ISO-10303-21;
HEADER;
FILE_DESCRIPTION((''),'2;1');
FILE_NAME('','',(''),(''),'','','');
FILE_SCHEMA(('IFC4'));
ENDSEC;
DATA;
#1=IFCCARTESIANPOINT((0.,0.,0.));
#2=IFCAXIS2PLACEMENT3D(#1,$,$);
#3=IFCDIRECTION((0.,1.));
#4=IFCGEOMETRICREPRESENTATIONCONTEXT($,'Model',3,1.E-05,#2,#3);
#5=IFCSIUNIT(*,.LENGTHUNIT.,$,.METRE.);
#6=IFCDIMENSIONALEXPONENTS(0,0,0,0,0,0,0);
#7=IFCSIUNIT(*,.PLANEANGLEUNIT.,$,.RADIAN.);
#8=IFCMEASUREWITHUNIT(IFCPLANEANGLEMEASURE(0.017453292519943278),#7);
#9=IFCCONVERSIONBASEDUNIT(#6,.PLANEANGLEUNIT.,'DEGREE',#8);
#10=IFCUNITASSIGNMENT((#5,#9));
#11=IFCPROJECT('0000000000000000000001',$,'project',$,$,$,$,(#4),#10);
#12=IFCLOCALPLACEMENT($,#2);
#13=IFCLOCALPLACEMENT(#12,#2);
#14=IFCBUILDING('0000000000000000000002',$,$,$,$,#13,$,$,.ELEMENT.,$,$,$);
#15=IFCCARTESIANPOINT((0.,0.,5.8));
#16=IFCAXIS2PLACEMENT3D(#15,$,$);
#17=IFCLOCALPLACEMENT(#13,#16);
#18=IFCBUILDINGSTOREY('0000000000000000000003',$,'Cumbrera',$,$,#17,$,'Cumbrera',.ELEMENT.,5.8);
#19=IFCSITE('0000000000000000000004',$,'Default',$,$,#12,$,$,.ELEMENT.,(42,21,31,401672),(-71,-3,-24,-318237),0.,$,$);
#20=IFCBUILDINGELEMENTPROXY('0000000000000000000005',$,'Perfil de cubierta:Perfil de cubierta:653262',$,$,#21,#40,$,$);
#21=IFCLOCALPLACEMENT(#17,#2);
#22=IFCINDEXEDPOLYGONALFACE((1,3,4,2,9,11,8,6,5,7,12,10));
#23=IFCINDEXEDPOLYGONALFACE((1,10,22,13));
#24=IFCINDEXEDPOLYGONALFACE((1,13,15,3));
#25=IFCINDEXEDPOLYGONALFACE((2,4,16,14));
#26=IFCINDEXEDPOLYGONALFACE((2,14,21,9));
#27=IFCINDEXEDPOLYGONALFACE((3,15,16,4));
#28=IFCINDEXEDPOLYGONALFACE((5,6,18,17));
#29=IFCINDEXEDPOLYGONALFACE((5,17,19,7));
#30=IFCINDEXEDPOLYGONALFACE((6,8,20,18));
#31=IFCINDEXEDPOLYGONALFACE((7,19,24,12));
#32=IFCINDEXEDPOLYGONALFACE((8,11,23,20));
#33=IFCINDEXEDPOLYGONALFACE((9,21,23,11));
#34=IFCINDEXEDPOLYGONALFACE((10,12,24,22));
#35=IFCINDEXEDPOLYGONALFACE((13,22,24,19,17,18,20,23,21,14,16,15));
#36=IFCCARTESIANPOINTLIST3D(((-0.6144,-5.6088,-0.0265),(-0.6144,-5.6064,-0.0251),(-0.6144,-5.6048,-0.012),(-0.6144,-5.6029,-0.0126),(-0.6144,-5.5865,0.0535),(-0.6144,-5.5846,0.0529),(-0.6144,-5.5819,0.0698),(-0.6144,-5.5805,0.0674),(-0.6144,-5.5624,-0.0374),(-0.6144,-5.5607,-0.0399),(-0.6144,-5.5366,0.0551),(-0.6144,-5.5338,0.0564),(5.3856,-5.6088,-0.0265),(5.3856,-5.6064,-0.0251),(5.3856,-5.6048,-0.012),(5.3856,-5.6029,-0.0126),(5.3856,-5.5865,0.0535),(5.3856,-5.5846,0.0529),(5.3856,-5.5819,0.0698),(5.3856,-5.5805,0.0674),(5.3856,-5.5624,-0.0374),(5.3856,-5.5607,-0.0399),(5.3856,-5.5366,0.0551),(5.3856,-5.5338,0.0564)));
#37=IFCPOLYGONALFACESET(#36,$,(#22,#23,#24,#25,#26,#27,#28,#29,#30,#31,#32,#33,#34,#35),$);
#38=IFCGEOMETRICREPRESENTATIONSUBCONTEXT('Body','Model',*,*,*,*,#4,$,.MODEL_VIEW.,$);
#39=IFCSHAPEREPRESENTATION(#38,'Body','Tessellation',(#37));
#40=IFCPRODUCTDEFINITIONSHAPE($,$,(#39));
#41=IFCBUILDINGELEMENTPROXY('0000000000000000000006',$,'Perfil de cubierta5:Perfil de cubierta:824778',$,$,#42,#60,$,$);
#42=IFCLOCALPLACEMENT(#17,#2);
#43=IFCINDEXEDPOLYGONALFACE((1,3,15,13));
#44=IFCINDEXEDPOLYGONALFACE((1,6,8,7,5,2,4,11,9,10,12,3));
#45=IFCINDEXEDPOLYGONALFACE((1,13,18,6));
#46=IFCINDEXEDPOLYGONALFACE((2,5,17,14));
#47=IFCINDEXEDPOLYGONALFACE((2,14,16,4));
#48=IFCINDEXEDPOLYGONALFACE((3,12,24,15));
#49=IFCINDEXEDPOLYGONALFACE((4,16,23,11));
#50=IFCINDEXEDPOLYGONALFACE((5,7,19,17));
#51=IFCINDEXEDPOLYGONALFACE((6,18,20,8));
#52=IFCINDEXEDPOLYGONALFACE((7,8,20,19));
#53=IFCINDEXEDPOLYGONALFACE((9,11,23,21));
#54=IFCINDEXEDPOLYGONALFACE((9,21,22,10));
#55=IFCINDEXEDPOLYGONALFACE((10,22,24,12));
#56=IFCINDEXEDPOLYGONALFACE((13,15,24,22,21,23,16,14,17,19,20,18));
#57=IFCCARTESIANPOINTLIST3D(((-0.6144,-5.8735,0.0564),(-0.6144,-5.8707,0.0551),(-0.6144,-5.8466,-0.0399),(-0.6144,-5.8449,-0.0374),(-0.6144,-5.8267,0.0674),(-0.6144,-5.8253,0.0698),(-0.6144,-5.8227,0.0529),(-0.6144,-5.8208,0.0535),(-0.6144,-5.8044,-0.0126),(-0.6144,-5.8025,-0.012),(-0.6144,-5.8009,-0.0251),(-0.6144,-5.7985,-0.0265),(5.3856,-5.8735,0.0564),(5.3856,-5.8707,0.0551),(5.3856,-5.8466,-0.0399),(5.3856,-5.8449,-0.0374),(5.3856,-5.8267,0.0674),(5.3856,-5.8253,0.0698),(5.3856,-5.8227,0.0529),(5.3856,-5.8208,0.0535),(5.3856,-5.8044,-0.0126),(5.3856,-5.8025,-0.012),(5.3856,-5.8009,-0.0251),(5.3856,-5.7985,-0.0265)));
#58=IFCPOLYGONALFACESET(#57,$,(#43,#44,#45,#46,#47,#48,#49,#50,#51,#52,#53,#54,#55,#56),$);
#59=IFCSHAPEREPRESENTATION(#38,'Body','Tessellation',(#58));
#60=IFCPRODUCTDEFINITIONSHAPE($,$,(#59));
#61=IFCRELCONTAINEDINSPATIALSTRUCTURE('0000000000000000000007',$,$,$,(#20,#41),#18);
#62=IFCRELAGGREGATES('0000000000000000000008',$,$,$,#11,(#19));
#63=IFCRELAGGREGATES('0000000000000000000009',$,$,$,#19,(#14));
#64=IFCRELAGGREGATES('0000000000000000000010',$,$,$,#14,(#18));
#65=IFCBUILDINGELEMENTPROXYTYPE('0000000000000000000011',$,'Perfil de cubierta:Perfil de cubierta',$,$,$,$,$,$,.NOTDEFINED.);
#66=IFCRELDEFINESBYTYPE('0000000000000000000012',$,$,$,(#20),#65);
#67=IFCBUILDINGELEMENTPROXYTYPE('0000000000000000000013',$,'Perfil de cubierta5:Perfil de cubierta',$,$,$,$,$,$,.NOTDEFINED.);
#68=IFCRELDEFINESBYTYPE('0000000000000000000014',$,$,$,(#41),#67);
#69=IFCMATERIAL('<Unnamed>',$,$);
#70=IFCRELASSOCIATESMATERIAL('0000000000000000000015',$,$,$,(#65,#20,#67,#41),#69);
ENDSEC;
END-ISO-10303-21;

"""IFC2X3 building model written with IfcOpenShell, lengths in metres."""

from ifc_helpers import new_model, entity, si_unit, converted_unit, direction, frame, origin, place, context, subcontext, project, spatial, polyline, outline, extrude, source, transform, mapped, material, type_object, type_shapes, element, save


model = new_model("IFC2X3")

# Units and contexts
model_context = context("Model", 3, precision=1e-05, world=origin(), true_north=direction((0.0, 1.0)))
body_context = subcontext(model_context, "Body", "Model", "MODEL_VIEW")
ifc_project = project(units=[si_unit("LENGTHUNIT", "METRE"), converted_unit("PLANEANGLEUNIT", "DEGREE", entity("IfcPlaneAngleMeasure", 0.017453292519943278), si_unit("PLANEANGLEUNIT", "RADIAN"), dimensions=[0, 0, 0, 0, 0, 0, 0])], contexts=[model_context])

# Site, building, storey
site_placement = place(None, origin())
site = spatial("IfcSite", under=ifc_project, at=site_placement, Name="Default", CompositionType="ELEMENT", RefLatitude=(42, 21, 31, 401672), RefLongitude=(-71, -3, -24, -318237), RefElevation=0.0)
building_placement = place(site_placement, origin())
building = spatial("IfcBuilding", under=site, at=building_placement, CompositionType="ELEMENT")
storey_placement = place(building_placement, frame((0.0, 0.0, 5.8)))
storey = spatial("IfcBuildingStorey", under=building, at=storey_placement, Name="Cumbrera", LongName="Cumbrera", CompositionType="ELEMENT", Elevation=5.8)

# Building element proxies
ifc_material_1 = material(Name="<Unnamed>")
building_element_proxy_type_1 = type_object("IfcBuildingElementProxyType", Name="Perfil de cubierta:Perfil de cubierta", PredefinedType="NOTDEFINED", material=ifc_material_1)
shared_shape_1 = source(origin(), body_context, "Body", "SweptSolid", [
    extrude(outline(polyline([(-0.0497, -0.0331), (0.0503, -0.0331), (0.0503, 0.0169), (0.0333, 0.0169), (0.0333, 0.0149), (0.0483, 0.0149), (0.0483, -0.0307), (-0.0477, -0.0307), (-0.0477, 0.0149), (-0.0347, 0.0149), (-0.0347, 0.0169), (-0.0497, 0.0169), (-0.0497, -0.0331)])), frame((-0.6144, -2.6512, 4.999), z_axis=(1.0, 0.0, 0.0), x_axis=(0.0, 0.268901, 0.963168)), (0.0, 0.0, 1.0), 6.0),
])
type_shapes(building_element_proxy_type_1, [shared_shape_1])
proxy_1_placement = place(storey_placement, frame((0.0, -2.9279, -4.9822)))
element("IfcBuildingElementProxy", 1, at=proxy_1_placement, inside=storey, type_object=building_element_proxy_type_1, material=ifc_material_1, Name="Perfil de cubierta:Perfil de cubierta:653262", context=body_context, shape_type="MappedRepresentation", body=[
    mapped(shared_shape_1, transform((0.0, 0.0, 0.0), scale=1.0)),
])
building_element_proxy_type_2 = type_object("IfcBuildingElementProxyType", Name="Perfil de cubierta5:Perfil de cubierta", PredefinedType="NOTDEFINED", material=ifc_material_1)
shared_shape_2 = source(origin(), body_context, "Body", "SweptSolid", [
    extrude(outline(polyline([(-0.0331, -0.0497), (0.0169, -0.0497), (0.0169, -0.0347), (0.0149, -0.0347), (0.0149, -0.0477), (-0.0307, -0.0477), (-0.0307, 0.0483), (0.0149, 0.0483), (0.0149, 0.0333), (0.0169, 0.0333), (0.0169, 0.0503), (-0.0331, 0.0503), (-0.0331, -0.0497)])), frame((-0.6144, -8.7561, 4.999), z_axis=(1.0, 0.0, 0.0), x_axis=(0.0, 0.963168, 0.268901)), (0.0, 0.0, 1.0), 6.0),
])
type_shapes(building_element_proxy_type_2, [shared_shape_2])
proxy_2_placement = place(storey_placement, frame((0.0, 2.9279, -4.9822)))
element("IfcBuildingElementProxy", 2, at=proxy_2_placement, inside=storey, type_object=building_element_proxy_type_2, material=ifc_material_1, Name="Perfil de cubierta5:Perfil de cubierta:824778", context=body_context, shape_type="MappedRepresentation", body=[
    mapped(shared_shape_2, transform((0.0, 0.0, 0.0), scale=1.0)),
])

save(model, "model.ifc")
